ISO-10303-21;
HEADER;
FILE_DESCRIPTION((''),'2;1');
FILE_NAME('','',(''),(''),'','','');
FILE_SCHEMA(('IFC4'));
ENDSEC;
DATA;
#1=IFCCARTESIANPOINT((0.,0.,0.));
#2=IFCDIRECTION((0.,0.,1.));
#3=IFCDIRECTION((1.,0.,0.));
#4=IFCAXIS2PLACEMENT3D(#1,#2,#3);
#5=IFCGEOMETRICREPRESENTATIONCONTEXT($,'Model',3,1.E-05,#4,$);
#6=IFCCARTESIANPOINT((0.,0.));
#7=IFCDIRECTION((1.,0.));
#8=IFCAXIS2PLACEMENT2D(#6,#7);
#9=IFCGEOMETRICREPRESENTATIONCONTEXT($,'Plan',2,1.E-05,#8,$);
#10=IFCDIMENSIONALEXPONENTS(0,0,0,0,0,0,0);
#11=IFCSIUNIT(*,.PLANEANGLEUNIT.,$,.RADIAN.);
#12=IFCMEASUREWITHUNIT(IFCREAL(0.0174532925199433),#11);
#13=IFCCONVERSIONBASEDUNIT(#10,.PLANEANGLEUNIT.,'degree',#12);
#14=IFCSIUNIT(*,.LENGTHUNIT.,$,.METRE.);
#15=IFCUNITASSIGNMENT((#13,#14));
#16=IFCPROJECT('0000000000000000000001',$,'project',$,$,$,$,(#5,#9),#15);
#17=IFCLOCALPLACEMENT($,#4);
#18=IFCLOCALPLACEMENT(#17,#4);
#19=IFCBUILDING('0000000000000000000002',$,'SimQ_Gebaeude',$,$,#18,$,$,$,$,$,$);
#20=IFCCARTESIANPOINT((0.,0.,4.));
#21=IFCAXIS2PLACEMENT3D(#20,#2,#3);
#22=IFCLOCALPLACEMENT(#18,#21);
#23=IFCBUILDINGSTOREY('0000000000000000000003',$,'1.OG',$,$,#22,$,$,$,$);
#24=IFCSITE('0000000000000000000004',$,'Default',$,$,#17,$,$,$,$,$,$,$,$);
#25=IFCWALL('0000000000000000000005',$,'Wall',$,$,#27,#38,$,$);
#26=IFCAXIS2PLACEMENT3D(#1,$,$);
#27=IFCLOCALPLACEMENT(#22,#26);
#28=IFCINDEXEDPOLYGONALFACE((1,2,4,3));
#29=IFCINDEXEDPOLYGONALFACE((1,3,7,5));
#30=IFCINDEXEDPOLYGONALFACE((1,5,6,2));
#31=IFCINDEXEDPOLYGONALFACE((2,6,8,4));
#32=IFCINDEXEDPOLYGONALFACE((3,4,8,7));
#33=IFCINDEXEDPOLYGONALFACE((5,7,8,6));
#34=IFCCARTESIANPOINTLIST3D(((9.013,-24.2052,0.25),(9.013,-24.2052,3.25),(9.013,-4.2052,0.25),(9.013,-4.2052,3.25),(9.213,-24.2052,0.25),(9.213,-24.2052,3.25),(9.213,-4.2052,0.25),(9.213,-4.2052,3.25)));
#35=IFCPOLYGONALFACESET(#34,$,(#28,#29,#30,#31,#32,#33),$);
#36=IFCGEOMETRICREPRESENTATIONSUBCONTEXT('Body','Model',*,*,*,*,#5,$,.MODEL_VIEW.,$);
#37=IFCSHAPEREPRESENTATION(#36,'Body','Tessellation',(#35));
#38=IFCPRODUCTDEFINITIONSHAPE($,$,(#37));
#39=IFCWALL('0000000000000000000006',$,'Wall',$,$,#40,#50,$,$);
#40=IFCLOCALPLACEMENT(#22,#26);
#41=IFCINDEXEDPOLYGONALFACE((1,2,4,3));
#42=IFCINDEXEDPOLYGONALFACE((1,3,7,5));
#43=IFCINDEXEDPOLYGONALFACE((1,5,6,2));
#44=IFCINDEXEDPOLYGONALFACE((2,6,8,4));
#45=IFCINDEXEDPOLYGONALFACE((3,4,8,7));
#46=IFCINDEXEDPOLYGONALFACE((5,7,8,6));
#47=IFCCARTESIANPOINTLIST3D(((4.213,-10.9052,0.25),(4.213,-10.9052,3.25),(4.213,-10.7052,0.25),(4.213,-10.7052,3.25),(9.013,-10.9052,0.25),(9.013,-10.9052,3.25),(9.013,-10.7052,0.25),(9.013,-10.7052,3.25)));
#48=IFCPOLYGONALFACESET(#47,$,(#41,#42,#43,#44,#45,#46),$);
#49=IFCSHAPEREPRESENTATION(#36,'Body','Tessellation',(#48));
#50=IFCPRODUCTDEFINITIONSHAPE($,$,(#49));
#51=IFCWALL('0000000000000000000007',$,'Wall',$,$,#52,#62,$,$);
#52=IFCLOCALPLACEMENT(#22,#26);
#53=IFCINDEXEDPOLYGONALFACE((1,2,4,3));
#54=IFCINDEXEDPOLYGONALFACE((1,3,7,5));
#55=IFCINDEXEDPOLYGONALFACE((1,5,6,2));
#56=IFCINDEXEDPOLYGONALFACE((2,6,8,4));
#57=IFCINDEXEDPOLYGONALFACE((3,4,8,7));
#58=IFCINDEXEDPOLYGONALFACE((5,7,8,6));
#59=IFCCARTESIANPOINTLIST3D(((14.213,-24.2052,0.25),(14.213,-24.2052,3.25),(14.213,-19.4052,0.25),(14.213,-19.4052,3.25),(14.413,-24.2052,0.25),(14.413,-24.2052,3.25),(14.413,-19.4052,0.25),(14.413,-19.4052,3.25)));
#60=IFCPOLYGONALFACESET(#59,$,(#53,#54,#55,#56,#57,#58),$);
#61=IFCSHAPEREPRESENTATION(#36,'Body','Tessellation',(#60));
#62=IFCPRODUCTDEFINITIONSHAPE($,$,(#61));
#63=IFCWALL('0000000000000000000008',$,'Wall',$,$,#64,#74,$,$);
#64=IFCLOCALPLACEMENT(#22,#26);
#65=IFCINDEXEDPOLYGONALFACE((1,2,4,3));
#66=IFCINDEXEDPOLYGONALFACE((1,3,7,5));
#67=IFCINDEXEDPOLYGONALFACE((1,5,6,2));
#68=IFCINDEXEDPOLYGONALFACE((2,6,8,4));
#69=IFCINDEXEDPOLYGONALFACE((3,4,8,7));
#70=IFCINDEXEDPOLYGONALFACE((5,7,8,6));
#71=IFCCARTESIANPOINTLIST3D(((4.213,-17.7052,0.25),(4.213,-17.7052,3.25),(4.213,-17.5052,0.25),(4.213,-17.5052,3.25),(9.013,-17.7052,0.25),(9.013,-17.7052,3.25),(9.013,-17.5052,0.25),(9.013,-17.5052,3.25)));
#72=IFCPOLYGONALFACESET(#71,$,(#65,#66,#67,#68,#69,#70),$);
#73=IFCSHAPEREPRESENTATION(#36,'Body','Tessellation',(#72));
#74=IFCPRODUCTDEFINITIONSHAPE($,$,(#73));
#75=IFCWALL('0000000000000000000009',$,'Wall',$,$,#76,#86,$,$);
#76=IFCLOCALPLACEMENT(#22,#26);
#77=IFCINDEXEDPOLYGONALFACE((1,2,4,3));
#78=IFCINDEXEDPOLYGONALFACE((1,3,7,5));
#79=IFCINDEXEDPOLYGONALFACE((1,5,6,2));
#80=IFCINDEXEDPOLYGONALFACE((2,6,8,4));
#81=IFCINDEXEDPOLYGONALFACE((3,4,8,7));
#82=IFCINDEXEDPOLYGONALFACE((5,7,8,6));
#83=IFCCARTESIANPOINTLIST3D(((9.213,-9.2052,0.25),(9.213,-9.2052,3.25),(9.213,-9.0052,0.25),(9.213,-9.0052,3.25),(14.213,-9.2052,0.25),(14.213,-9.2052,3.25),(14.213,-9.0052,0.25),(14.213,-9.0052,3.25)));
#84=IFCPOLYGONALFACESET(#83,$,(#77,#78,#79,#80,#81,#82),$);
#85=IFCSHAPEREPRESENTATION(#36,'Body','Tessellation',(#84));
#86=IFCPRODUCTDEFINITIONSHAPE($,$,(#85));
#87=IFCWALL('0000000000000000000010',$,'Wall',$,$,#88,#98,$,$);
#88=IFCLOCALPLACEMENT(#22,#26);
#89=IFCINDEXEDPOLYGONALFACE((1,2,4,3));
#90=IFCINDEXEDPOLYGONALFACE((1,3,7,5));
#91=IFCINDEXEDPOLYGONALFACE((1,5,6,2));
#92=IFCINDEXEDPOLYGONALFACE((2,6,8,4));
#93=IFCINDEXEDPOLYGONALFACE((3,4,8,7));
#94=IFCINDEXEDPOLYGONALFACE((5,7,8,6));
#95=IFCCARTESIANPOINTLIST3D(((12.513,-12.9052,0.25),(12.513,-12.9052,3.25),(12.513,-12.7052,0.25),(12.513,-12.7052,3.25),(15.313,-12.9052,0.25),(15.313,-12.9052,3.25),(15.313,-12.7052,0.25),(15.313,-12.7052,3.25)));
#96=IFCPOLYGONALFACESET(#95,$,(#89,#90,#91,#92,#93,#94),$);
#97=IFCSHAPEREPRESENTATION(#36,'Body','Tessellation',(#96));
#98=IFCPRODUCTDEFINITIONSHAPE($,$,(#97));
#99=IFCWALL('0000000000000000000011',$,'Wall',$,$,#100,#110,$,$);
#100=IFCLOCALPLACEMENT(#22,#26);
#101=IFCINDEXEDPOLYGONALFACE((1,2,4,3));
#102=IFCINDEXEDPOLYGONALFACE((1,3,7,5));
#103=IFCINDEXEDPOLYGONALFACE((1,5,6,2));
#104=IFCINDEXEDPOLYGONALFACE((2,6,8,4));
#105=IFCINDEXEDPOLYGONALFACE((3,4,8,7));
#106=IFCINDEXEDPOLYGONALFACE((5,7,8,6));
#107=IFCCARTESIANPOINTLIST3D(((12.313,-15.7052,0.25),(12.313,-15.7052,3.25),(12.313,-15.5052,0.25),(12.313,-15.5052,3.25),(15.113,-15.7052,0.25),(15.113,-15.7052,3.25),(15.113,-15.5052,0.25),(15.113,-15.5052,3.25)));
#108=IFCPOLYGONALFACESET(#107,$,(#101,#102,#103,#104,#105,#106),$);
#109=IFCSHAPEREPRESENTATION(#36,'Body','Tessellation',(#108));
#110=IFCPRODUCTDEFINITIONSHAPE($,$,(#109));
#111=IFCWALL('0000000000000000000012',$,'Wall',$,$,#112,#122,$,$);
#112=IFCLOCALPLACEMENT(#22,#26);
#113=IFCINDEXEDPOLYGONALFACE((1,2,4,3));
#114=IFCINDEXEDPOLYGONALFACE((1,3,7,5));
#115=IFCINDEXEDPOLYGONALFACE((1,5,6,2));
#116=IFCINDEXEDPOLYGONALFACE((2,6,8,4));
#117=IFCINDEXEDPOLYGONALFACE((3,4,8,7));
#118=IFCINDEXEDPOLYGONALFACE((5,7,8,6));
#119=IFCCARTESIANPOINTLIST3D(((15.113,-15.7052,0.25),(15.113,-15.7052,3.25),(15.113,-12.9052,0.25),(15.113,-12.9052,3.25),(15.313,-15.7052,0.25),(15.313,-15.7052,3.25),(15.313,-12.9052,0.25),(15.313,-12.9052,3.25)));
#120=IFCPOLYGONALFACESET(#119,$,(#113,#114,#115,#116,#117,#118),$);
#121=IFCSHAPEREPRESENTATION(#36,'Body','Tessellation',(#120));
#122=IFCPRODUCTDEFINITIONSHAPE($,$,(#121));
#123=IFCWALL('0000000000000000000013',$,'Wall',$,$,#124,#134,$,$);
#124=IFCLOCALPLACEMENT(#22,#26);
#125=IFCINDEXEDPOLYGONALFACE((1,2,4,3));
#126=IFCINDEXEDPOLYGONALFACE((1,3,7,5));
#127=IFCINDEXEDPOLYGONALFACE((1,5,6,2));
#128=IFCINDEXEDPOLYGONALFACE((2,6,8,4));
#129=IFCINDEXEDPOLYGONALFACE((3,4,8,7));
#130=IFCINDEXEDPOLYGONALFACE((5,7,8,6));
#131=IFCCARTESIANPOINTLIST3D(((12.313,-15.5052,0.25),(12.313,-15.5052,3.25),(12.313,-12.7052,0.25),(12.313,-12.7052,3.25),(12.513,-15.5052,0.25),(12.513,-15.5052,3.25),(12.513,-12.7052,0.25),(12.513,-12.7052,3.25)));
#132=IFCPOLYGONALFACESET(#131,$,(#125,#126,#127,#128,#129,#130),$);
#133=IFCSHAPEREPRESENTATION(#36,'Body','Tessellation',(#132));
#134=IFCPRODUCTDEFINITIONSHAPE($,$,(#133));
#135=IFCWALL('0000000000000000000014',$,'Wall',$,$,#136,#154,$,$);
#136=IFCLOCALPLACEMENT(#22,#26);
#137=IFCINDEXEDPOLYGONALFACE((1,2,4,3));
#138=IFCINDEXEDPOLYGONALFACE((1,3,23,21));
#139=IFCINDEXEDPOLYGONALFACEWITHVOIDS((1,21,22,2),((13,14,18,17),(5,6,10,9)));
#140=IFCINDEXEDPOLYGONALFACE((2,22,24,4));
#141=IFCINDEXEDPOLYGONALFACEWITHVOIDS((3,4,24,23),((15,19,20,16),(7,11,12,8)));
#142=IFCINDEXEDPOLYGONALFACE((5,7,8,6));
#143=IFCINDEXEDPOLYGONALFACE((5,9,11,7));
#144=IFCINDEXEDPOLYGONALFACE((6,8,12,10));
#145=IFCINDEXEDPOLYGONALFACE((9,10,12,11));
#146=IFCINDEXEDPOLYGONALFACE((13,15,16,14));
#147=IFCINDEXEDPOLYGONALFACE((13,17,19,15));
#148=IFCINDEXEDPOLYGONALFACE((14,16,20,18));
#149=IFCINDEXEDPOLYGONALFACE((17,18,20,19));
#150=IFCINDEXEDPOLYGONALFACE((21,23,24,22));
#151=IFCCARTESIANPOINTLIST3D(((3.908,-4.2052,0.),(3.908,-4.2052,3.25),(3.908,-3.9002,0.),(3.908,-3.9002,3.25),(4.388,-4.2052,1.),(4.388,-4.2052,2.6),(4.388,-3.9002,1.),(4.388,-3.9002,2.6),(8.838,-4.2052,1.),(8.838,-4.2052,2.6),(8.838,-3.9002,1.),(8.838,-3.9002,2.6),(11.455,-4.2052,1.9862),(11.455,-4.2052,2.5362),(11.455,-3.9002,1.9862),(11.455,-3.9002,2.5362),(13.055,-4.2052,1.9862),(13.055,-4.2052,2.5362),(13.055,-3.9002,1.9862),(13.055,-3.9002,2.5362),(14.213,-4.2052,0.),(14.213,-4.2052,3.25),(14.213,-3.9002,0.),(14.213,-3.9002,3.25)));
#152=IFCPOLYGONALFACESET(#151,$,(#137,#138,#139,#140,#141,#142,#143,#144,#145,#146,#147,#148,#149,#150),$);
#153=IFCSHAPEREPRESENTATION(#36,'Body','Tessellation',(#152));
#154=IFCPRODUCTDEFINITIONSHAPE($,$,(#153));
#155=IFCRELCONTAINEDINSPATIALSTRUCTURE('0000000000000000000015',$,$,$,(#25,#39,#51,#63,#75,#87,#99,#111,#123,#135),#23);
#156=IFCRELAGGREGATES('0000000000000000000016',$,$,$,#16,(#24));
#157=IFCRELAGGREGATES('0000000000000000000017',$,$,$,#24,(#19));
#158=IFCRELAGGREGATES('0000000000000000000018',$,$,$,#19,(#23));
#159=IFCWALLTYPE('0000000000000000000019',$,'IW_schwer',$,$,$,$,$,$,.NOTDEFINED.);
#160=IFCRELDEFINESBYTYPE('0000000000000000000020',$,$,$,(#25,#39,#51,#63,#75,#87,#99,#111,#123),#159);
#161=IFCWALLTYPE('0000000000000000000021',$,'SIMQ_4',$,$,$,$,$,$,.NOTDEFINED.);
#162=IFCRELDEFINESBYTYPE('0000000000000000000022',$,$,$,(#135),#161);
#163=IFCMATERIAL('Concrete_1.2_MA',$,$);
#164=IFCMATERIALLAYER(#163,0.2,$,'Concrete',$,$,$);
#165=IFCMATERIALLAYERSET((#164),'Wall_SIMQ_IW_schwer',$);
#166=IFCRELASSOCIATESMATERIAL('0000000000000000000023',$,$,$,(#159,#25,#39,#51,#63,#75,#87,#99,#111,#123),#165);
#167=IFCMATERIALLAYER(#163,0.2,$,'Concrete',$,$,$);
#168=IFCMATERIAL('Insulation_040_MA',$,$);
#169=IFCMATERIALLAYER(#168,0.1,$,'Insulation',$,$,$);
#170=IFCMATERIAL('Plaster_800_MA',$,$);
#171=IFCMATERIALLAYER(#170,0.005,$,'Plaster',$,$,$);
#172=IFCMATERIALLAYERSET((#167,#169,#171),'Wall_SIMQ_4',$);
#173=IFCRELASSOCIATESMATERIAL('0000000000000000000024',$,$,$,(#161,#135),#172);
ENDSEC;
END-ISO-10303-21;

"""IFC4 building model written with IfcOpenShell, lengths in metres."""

from ifc_helpers import new_model, entity, si_unit, converted_unit, frame, origin_with_axes, origin_2d_with_axis, place, context, subcontext, project, spatial, line, indexed_curve, outline, extrude, source, transform, mapped, material, layer, layer_set, layer_usage, type_object, element, save


model = new_model("IFC4")

# Units and contexts
model_context = context("Model", 3, precision=1e-05, world=origin_with_axes())
plan_context = context("Plan", 2, precision=1e-05, world=origin_2d_with_axis())
body_context = subcontext(model_context, "Body", "Model", "MODEL_VIEW")
ifc_project = project(units=[converted_unit("PLANEANGLEUNIT", "degree", entity("IfcReal", 0.0174532925199433), si_unit("PLANEANGLEUNIT", "RADIAN"), dimensions=[0, 0, 0, 0, 0, 0, 0]), si_unit("LENGTHUNIT", "METRE")], contexts=[model_context, plan_context])

# Site, building, storey
site_placement = place(None, origin_with_axes())
site = spatial("IfcSite", under=ifc_project, at=site_placement, Name="Default")
building_placement = place(site_placement, origin_with_axes())
building = spatial("IfcBuilding", under=site, at=building_placement, Name="SimQ_Gebaeude")
storey_placement = place(building_placement, frame((0.0, 0.0, 4.0), z_axis=(0.0, 0.0, 1.0), x_axis=(1.0, 0.0, 0.0)))
storey = spatial("IfcBuildingStorey", under=building, at=storey_placement, Name="1.OG")

# Shared definitions
ifc_material_1 = material(Name="Insulation_040_MA")
ifc_material_2 = material(Name="Concrete_1.2_MA")

# Walls
ifc_layer_1 = layer(ifc_material_2, 0.2, Name="Concrete")
ifc_layer_set_1 = layer_set([ifc_layer_1], Name="Wall_SIMQ_IW_schwer")
ifc_layer_usage_1 = layer_usage(ifc_layer_set_1, "AXIS2", "POSITIVE", 0.0)
wall_type_1 = type_object("IfcWallType", Name="IW_schwer", PredefinedType="NOTDEFINED", material=ifc_layer_set_1)
wall_1_placement = place(storey_placement, frame((9.213, -24.2052, 0.25), z_axis=(0.0, 0.0, 1.0), x_axis=(0.000001, 1.0, 0.0)))
element("IfcWall", 1, at=wall_1_placement, inside=storey, type_object=wall_type_1, material=ifc_layer_usage_1, Name="Wall", context=body_context, shape_type="SweptSolid", body=[
    extrude(outline(indexed_curve([(0.0, 0.0), (0.0, 0.2), (20.0, 0.2), (20.0, 0.0), (0.0, 0.0)], self_intersect=False)), origin_with_axes(), (0.0, 0.0, 1.0), 3.0),
])
ifc_layer_usage_2 = layer_usage(ifc_layer_set_1, "AXIS2", "POSITIVE", 0.0)
wall_2_placement = place(storey_placement, frame((9.013, -10.7052, 0.25), z_axis=(0.0, 0.0, 1.0), x_axis=(-1.0, 0.000001, 0.0)))
element("IfcWall", 2, at=wall_2_placement, inside=storey, type_object=wall_type_1, material=ifc_layer_usage_2, Name="Wall", context=body_context, shape_type="SweptSolid", body=[
    extrude(outline(indexed_curve([(0.0, 0.0), (0.0, 0.2), (4.8, 0.2), (4.8, 0.0), (0.0, 0.0)], self_intersect=False)), origin_with_axes(), (0.0, 0.0, 1.0), 3.0),
])
ifc_layer_usage_3 = layer_usage(ifc_layer_set_1, "AXIS2", "POSITIVE", 0.0)
wall_3_placement = place(storey_placement, frame((14.213, -19.4052, 0.25), z_axis=(0.0, 0.0, 1.0), x_axis=(-0.000001, -1.0, 0.0)))
element("IfcWall", 3, at=wall_3_placement, inside=storey, type_object=wall_type_1, material=ifc_layer_usage_3, Name="Wall", context=body_context, shape_type="SweptSolid", body=[
    extrude(outline(indexed_curve([(0.0, 0.0), (0.0, 0.2), (4.8, 0.2), (4.8, 0.0), (0.0, 0.0)], self_intersect=False)), origin_with_axes(), (0.0, 0.0, 1.0), 3.0),
])
ifc_layer_usage_4 = layer_usage(ifc_layer_set_1, "AXIS2", "POSITIVE", 0.0)
wall_4_placement = place(storey_placement, frame((9.013, -17.5052, 0.25), z_axis=(0.0, 0.0, 1.0), x_axis=(-1.0, 0.000001, 0.0)))
element("IfcWall", 4, at=wall_4_placement, inside=storey, type_object=wall_type_1, material=ifc_layer_usage_4, Name="Wall", context=body_context, shape_type="SweptSolid", body=[
    extrude(outline(indexed_curve([(0.0, 0.0), (0.0, 0.2), (4.8, 0.2), (4.8, 0.0), (0.0, 0.0)], self_intersect=False)), origin_with_axes(), (0.0, 0.0, 1.0), 3.0),
])
ifc_layer_usage_5 = layer_usage(ifc_layer_set_1, "AXIS2", "POSITIVE", 0.0)
wall_5_placement = place(storey_placement, frame((9.213, -9.2052, 0.25), z_axis=(0.0, 0.0, 1.0), x_axis=(1.0, 0.0, 0.0)))
element("IfcWall", 5, at=wall_5_placement, inside=storey, type_object=wall_type_1, material=ifc_layer_usage_5, Name="Wall", context=body_context, shape_type="SweptSolid", body=[
    extrude(outline(indexed_curve([(0.0, 0.0), (0.0, 0.2), (5.0, 0.2), (5.0, 0.0), (0.0, 0.0)], self_intersect=False)), origin_with_axes(), (0.0, 0.0, 1.0), 3.0),
])
ifc_layer_usage_6 = layer_usage(ifc_layer_set_1, "AXIS2", "POSITIVE", 0.0)
wall_6_placement = place(storey_placement, frame((15.313, -12.7052, 0.25), z_axis=(0.0, 0.0, 1.0), x_axis=(-1.0, 0.0, 0.0)))
element("IfcWall", 6, at=wall_6_placement, inside=storey, type_object=wall_type_1, material=ifc_layer_usage_6, Name="Wall", context=body_context, shape_type="SweptSolid", body=[
    extrude(outline(indexed_curve([(0.0, 0.0), (0.0, 0.2), (2.8, 0.2), (2.8, 0.0), (0.0, 0.0)], self_intersect=False)), origin_with_axes(), (0.0, 0.0, 1.0), 3.0),
])
ifc_layer_usage_7 = layer_usage(ifc_layer_set_1, "AXIS2", "POSITIVE", 0.0)
wall_7_placement = place(storey_placement, frame((15.113, -15.5052, 0.25), z_axis=(0.0, 0.0, 1.0), x_axis=(-1.0, 0.0, 0.0)))
element("IfcWall", 7, at=wall_7_placement, inside=storey, type_object=wall_type_1, material=ifc_layer_usage_7, Name="Wall", context=body_context, shape_type="SweptSolid", body=[
    extrude(outline(indexed_curve([(0.0, 0.0), (0.0, 0.2), (2.8, 0.2), (2.8, 0.0), (0.0, 0.0)], self_intersect=False)), origin_with_axes(), (0.0, 0.0, 1.0), 3.0),
])
ifc_layer_usage_8 = layer_usage(ifc_layer_set_1, "AXIS2", "POSITIVE", 0.0)
wall_8_placement = place(storey_placement, frame((15.113, -12.9052, 0.25), z_axis=(0.0, 0.0, 1.0), x_axis=(-0.000001, -1.0, 0.0)))
element("IfcWall", 8, at=wall_8_placement, inside=storey, type_object=wall_type_1, material=ifc_layer_usage_8, Name="Wall", context=body_context, shape_type="SweptSolid", body=[
    extrude(outline(indexed_curve([(0.0, 0.0), (0.0, 0.2), (2.8, 0.2), (2.8, 0.0), (0.0, 0.0)], self_intersect=False)), origin_with_axes(), (0.0, 0.0, 1.0), 3.0),
])
ifc_layer_usage_9 = layer_usage(ifc_layer_set_1, "AXIS2", "POSITIVE", 0.0)
wall_9_placement = place(storey_placement, frame((12.513, -15.5052, 0.25), z_axis=(0.0, 0.0, 1.0), x_axis=(0.000001, 1.0, 0.0)))
element("IfcWall", 9, at=wall_9_placement, inside=storey, type_object=wall_type_1, material=ifc_layer_usage_9, Name="Wall", context=body_context, shape_type="SweptSolid", body=[
    extrude(outline(indexed_curve([(0.0, 0.0), (0.0, 0.2), (2.8, 0.2), (2.8, 0.0), (0.0, 0.0)], self_intersect=False)), origin_with_axes(), (0.0, 0.0, 1.0), 3.0),
])

# Wall, openings
ifc_layer_2 = layer(ifc_material_2, 0.2, Name="Concrete")
ifc_layer_3 = layer(ifc_material_1, 0.1, Name="Insulation")
ifc_material_3 = material(Name="Plaster_800_MA")
ifc_layer_4 = layer(ifc_material_3, 0.005, Name="Plaster")
ifc_layer_set_2 = layer_set([ifc_layer_2, ifc_layer_3, ifc_layer_4], Name="Wall_SIMQ_4")
ifc_layer_usage_10 = layer_usage(ifc_layer_set_2, "AXIS2", "POSITIVE", 0.0)
wall_type_2 = type_object("IfcWallType", Name="SIMQ_4", PredefinedType="NOTDEFINED", material=ifc_layer_set_2)
wall_10_placement = place(storey_placement, frame((14.213, -3.9002, 0.0), z_axis=(0.0, 0.0, 1.0), x_axis=(-1.0, 0.0, 0.0)))
wall_10 = element("IfcWall", 10, at=wall_10_placement, inside=storey, type_object=wall_type_2, material=ifc_layer_usage_10, Name="Wall", context=body_context, shape_type="SweptSolid", body=[
    extrude(outline(indexed_curve([(0.0, 0.0), (0.0, 0.305), (10.305, 0.305), (10.305, 0.0), (0.0, 0.0)], self_intersect=False)), origin_with_axes(), (0.0, 0.0, 1.0), 3.25),
])
shared_shape_1 = source(origin_with_axes(), body_context, "Body", "SweptSolid", [
    extrude(outline(indexed_curve([(0.0, 0.0), (1.6, 0.0), (1.6, 0.55), (0.0, 0.55)], segments=[line(1, 2, 3, 4, 1)])), frame((0.0, -0.6, 0.0), z_axis=(0.0, -1.0, 0.0), x_axis=(1.0, 0.0, 0.0)), (0.0, 0.0, -1.0), 1.2),
])
opening_1_placement = place(wall_10_placement, frame((1.158, 0.0, 1.9862), z_axis=(0.0, 0.0, 1.0), x_axis=(1.0, 0.0, 0.0)))
element("IfcOpeningElement", 11, at=opening_1_placement, cuts=wall_10, PredefinedType="OPENING", context=body_context, shape_type="MappedRepresentation", body=[
    mapped(shared_shape_1, transform((0.0, 0.0, 0.0), x_axis=(1.0, 0.0, 0.0), y_axis=(0.0, 1.0, 0.0), z_axis=(0.0, 0.0, 1.0), scale=1.0)),
])
shared_shape_2 = source(origin_with_axes(), body_context, "Body", "SweptSolid", [
    extrude(outline(indexed_curve([(0.0, 0.0), (4.45, 0.0), (4.45, 1.6), (0.0, 1.6)], segments=[line(1, 2, 3, 4, 1)])), frame((0.0, -0.6, 0.0), z_axis=(0.0, -1.0, 0.0), x_axis=(1.0, 0.0, 0.0)), (0.0, 0.0, -1.0), 1.2),
])
opening_2_placement = place(wall_10_placement, frame((5.375, 0.0, 1.0), z_axis=(0.0, 0.0, 1.0), x_axis=(1.0, 0.0, 0.0)))
element("IfcOpeningElement", 12, at=opening_2_placement, cuts=wall_10, PredefinedType="OPENING", context=body_context, shape_type="MappedRepresentation", body=[
    mapped(shared_shape_2, transform((0.0, 0.0, 0.0), x_axis=(1.0, 0.0, 0.0), y_axis=(0.0, 1.0, 0.0), z_axis=(0.0, 0.0, 1.0), scale=1.0)),
])

save(model, "model.ifc")
